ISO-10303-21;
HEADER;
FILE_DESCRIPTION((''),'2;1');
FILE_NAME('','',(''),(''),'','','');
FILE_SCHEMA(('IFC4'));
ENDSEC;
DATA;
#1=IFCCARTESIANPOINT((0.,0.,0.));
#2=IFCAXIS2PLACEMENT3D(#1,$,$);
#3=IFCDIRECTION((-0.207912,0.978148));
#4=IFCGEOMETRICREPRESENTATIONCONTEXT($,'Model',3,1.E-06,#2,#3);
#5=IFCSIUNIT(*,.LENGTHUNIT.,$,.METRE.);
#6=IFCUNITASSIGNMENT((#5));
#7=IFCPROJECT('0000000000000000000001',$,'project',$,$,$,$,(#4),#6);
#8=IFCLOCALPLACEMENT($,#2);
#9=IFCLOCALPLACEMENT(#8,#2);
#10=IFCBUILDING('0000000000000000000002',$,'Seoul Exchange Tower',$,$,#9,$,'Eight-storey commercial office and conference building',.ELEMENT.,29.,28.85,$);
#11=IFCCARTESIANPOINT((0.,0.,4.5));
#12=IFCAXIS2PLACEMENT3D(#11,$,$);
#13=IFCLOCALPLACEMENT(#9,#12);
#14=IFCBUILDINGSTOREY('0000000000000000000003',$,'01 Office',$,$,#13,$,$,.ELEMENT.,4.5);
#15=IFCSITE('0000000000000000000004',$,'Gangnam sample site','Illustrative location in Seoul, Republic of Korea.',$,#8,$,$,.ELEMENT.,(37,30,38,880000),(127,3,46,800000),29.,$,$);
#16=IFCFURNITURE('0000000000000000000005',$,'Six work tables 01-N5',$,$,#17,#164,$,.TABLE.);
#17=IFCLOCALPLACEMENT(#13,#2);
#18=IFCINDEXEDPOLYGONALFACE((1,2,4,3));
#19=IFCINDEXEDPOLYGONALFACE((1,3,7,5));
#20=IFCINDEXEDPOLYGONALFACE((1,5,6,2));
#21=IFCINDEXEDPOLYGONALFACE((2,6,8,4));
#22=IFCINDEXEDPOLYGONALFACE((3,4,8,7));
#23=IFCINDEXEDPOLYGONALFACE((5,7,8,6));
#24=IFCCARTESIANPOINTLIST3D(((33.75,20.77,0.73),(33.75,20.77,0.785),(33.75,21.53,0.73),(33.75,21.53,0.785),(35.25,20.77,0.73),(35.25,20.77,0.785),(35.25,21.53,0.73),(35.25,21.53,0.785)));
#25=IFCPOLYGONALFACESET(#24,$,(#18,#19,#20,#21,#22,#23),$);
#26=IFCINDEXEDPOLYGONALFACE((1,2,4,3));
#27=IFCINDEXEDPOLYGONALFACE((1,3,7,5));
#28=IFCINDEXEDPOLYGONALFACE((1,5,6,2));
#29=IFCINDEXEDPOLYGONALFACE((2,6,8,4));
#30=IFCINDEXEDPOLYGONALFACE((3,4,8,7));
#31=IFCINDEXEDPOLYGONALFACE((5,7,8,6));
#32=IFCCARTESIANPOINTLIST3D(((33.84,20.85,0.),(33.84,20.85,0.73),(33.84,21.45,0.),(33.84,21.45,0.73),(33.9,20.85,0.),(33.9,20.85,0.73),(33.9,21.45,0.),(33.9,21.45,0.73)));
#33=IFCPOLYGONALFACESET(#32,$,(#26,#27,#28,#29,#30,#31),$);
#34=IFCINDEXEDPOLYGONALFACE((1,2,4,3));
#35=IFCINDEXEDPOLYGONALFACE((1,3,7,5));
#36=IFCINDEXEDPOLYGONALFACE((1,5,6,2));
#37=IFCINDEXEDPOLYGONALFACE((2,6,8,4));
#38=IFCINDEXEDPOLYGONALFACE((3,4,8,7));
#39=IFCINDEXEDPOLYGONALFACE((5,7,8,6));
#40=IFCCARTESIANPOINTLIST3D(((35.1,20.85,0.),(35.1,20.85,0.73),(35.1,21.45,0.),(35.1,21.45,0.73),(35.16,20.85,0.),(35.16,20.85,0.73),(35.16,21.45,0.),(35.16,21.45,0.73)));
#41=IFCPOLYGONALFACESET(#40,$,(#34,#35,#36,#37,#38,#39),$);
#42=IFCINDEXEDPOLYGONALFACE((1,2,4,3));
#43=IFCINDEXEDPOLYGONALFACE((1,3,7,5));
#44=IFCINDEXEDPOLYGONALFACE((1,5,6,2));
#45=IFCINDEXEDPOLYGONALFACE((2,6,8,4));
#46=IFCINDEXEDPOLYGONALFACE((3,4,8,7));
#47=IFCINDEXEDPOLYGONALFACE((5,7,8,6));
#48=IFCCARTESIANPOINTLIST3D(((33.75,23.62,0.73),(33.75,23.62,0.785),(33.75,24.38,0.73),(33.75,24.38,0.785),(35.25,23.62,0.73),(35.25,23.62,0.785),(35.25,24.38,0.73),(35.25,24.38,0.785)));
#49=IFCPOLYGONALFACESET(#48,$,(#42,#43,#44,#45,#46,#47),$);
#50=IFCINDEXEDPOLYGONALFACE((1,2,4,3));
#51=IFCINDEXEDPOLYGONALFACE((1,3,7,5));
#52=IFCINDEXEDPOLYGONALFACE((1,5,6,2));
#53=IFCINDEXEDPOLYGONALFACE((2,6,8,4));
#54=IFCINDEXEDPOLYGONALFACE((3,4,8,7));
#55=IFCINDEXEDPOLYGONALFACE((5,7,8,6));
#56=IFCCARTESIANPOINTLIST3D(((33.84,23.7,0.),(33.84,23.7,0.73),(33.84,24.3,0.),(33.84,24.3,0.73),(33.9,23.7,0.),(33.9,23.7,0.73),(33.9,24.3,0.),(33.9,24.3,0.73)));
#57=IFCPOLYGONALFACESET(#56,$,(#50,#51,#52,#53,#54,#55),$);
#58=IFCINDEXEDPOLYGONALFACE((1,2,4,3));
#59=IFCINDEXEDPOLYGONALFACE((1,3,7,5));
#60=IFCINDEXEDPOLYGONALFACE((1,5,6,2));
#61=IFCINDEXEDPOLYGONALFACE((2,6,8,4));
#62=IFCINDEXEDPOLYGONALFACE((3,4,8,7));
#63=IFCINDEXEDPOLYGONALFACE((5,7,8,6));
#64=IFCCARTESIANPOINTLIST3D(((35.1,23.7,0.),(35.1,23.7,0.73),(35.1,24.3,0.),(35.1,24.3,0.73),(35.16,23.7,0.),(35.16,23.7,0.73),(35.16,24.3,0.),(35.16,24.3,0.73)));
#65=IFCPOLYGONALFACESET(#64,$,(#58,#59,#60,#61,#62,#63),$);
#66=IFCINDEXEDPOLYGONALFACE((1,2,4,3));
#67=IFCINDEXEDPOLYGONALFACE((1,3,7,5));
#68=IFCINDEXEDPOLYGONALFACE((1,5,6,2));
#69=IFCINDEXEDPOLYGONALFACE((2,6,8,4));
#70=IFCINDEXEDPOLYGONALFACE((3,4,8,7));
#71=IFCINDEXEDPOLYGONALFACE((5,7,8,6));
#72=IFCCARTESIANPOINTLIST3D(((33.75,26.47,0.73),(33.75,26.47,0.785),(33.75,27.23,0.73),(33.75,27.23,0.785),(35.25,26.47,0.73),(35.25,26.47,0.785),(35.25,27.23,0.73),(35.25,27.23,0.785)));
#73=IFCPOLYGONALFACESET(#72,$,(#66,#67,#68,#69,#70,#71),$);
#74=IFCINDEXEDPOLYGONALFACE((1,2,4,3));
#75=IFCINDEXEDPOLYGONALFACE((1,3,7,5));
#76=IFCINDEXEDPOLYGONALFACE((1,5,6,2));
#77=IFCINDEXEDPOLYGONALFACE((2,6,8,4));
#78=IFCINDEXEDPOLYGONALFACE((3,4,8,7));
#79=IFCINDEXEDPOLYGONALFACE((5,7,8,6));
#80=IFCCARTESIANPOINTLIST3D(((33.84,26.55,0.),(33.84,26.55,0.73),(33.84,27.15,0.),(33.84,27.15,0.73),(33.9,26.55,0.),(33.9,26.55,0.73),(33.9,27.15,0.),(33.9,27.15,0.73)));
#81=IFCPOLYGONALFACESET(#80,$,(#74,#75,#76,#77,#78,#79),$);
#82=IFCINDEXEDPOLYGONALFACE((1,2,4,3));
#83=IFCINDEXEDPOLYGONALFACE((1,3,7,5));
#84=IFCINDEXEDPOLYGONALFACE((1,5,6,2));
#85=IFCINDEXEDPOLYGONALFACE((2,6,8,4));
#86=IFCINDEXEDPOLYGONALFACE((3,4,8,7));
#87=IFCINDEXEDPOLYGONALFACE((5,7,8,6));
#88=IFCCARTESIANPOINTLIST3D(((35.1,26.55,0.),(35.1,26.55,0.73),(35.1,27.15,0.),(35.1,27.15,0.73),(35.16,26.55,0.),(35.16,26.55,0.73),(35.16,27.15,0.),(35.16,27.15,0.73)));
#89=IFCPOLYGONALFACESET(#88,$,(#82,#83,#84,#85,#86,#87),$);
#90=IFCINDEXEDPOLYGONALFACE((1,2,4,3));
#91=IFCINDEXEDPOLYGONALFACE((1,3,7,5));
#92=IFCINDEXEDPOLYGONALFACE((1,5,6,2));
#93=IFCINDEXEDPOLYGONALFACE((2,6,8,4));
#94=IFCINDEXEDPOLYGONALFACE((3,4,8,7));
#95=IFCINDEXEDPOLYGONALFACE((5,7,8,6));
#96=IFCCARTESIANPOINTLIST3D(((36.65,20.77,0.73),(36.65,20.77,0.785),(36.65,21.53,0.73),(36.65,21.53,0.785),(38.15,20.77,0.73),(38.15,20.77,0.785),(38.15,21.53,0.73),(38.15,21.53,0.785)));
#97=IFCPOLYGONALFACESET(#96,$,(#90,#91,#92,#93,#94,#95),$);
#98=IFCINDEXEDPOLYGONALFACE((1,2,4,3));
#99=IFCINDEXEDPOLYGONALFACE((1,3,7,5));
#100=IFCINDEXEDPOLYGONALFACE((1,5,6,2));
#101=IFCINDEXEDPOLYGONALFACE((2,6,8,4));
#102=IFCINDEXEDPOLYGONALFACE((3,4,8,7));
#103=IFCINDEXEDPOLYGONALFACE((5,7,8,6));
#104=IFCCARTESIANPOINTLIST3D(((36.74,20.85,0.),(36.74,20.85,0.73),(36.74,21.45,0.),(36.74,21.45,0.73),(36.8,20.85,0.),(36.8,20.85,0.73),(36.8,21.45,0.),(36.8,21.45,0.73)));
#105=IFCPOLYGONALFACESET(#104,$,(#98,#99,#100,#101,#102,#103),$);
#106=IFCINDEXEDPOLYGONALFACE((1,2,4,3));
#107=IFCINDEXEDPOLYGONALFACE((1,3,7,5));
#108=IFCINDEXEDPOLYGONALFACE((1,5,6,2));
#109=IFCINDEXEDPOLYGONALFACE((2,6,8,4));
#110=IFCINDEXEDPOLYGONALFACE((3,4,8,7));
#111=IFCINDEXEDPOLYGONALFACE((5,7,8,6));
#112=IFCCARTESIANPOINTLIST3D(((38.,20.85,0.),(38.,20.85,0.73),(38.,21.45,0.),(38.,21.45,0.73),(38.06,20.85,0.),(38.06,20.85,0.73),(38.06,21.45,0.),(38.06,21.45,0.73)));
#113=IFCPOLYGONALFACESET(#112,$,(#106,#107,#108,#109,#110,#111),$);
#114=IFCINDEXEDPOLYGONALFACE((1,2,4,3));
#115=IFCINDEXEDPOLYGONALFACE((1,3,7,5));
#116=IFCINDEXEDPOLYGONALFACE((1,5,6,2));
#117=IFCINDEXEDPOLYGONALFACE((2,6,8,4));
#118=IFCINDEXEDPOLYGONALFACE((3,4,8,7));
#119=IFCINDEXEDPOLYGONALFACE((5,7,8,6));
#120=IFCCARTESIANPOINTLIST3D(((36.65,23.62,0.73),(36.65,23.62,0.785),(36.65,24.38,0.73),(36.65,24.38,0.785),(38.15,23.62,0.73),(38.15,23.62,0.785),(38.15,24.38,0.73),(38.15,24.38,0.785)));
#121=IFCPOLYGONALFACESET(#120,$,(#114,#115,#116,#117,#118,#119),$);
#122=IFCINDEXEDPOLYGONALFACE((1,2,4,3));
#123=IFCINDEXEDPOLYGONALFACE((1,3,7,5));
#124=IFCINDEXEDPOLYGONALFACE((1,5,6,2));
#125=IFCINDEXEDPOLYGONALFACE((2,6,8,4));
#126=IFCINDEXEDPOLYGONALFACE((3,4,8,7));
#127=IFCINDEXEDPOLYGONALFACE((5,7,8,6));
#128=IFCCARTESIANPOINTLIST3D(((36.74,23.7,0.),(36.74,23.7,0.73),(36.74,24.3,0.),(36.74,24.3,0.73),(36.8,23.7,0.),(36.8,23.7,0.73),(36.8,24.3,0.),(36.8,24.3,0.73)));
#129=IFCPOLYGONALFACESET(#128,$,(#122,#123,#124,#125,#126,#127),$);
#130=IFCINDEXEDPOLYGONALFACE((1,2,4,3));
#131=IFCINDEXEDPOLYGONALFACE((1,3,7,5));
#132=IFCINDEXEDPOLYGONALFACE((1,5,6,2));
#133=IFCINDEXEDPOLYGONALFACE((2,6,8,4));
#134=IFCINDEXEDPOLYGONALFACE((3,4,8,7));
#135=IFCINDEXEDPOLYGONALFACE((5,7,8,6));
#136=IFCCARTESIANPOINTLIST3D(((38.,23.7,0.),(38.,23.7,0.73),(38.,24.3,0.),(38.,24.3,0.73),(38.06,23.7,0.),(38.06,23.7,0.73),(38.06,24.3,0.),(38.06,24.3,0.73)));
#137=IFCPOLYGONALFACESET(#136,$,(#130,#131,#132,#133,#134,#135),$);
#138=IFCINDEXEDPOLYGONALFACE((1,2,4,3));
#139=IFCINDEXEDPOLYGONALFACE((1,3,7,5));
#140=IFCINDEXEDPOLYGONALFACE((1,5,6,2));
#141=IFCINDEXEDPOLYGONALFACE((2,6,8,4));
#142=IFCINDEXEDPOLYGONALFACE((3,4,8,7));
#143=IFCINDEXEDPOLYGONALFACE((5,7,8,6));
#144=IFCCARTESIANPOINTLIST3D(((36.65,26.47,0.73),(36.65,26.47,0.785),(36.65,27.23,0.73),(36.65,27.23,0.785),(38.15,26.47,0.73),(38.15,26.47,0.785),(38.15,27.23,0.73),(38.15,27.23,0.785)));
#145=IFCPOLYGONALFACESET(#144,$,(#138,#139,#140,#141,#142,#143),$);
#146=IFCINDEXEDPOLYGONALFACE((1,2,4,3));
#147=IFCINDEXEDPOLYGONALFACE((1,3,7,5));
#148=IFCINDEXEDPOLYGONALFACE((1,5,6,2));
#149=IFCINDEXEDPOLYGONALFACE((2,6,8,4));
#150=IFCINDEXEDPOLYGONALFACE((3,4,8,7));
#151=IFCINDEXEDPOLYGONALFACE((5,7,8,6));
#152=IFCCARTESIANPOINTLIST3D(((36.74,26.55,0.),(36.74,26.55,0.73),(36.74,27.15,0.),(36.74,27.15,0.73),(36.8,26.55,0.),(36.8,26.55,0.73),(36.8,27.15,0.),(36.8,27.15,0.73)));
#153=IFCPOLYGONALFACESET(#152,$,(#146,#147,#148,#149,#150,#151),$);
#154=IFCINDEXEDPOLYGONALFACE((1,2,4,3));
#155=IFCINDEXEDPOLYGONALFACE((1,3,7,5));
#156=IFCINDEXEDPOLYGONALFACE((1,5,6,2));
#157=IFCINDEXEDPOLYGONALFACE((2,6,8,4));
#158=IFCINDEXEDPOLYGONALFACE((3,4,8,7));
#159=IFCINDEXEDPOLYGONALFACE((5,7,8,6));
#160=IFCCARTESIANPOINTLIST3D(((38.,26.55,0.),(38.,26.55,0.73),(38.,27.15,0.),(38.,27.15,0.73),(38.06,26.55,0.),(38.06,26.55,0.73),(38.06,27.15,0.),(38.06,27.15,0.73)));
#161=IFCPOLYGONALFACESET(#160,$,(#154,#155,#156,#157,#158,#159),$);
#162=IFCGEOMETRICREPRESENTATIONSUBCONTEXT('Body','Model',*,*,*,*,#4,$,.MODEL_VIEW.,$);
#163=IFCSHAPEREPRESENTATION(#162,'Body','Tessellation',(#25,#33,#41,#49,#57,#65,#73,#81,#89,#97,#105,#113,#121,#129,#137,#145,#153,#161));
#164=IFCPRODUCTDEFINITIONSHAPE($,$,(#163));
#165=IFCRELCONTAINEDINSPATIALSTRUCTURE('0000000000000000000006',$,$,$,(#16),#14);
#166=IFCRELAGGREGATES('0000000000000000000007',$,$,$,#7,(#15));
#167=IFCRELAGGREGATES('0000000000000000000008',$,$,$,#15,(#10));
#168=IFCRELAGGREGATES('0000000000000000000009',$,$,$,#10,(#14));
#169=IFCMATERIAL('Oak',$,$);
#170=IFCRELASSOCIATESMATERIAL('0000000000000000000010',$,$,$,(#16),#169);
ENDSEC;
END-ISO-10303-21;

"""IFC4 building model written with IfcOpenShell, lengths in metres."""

from ifc_helpers import new_model, si_unit, direction, frame, frame_2d, origin, place, context, subcontext, project, spatial, rectangle, extrude, material, element, save


model = new_model("IFC4")

# Units and contexts
model_context = context("Model", 3, precision=1e-06, world=origin(), true_north=direction((-0.207912, 0.978148)))
body_context = subcontext(model_context, "Body", "Model", "MODEL_VIEW")
ifc_project = project(units=[si_unit("LENGTHUNIT", "METRE")], contexts=[model_context])

# Site, building, storey
site_placement = place(None, origin())
site = spatial("IfcSite", under=ifc_project, at=site_placement, Name="Gangnam sample site", Description="Illustrative location in Seoul, Republic of Korea.", CompositionType="ELEMENT", RefLatitude=(37, 30, 38, 880000), RefLongitude=(127, 3, 46, 800000), RefElevation=29.0)
building_placement = place(site_placement, origin())
building = spatial("IfcBuilding", under=site, at=building_placement, Name="Seoul Exchange Tower", LongName="Eight-storey commercial office and conference building", CompositionType="ELEMENT", ElevationOfRefHeight=29.0, ElevationOfTerrain=28.85)
storey_placement = place(building_placement, frame((0.0, 0.0, 4.5)))
storey = spatial("IfcBuildingStorey", under=building, at=storey_placement, Name="01 Office", CompositionType="ELEMENT", Elevation=4.5)

# Shared definitions
placement_1 = place(storey_placement, origin())

# Furniture
ifc_material_1 = material(Name="Oak")
element("IfcFurniture", 1, at=placement_1, inside=storey, material=ifc_material_1, Name="Six work tables 01-N5", PredefinedType="TABLE", context=body_context, shape_type="SweptSolid", body=[
    extrude(rectangle(XDim=1.5, YDim=0.76, at=frame_2d((0.75, 0.38))), frame((33.75, 20.77, 0.73)), (0.0, 0.0, 1.0), 0.055),
    extrude(rectangle(XDim=0.06, YDim=0.6, at=frame_2d((0.03, 0.3))), frame((33.84, 20.85, 0.0)), (0.0, 0.0, 1.0), 0.73),
    extrude(rectangle(XDim=0.06, YDim=0.6, at=frame_2d((0.03, 0.3))), frame((35.1, 20.85, 0.0)), (0.0, 0.0, 1.0), 0.73),
    extrude(rectangle(XDim=1.5, YDim=0.76, at=frame_2d((0.75, 0.38))), frame((33.75, 23.62, 0.73)), (0.0, 0.0, 1.0), 0.055),
    extrude(rectangle(XDim=0.06, YDim=0.6, at=frame_2d((0.03, 0.3))), frame((33.84, 23.7, 0.0)), (0.0, 0.0, 1.0), 0.73),
    extrude(rectangle(XDim=0.06, YDim=0.6, at=frame_2d((0.03, 0.3))), frame((35.1, 23.7, 0.0)), (0.0, 0.0, 1.0), 0.73),
    extrude(rectangle(XDim=1.5, YDim=0.76, at=frame_2d((0.75, 0.38))), frame((33.75, 26.47, 0.73)), (0.0, 0.0, 1.0), 0.055),
    extrude(rectangle(XDim=0.06, YDim=0.6, at=frame_2d((0.03, 0.3))), frame((33.84, 26.55, 0.0)), (0.0, 0.0, 1.0), 0.73),
    extrude(rectangle(XDim=0.06, YDim=0.6, at=frame_2d((0.03, 0.3))), frame((35.1, 26.55, 0.0)), (0.0, 0.0, 1.0), 0.73),
    extrude(rectangle(XDim=1.5, YDim=0.76, at=frame_2d((0.75, 0.38))), frame((36.65, 20.77, 0.73)), (0.0, 0.0, 1.0), 0.055),
    extrude(rectangle(XDim=0.06, YDim=0.6, at=frame_2d((0.03, 0.3))), frame((36.74, 20.85, 0.0)), (0.0, 0.0, 1.0), 0.73),
    extrude(rectangle(XDim=0.06, YDim=0.6, at=frame_2d((0.03, 0.3))), frame((38.0, 20.85, 0.0)), (0.0, 0.0, 1.0), 0.73),
    extrude(rectangle(XDim=1.5, YDim=0.76, at=frame_2d((0.75, 0.38))), frame((36.65, 23.62, 0.73)), (0.0, 0.0, 1.0), 0.055),
    extrude(rectangle(XDim=0.06, YDim=0.6, at=frame_2d((0.03, 0.3))), frame((36.74, 23.7, 0.0)), (0.0, 0.0, 1.0), 0.73),
    extrude(rectangle(XDim=0.06, YDim=0.6, at=frame_2d((0.03, 0.3))), frame((38.0, 23.7, 0.0)), (0.0, 0.0, 1.0), 0.73),
    extrude(rectangle(XDim=1.5, YDim=0.76, at=frame_2d((0.75, 0.38))), frame((36.65, 26.47, 0.73)), (0.0, 0.0, 1.0), 0.055),
    extrude(rectangle(XDim=0.06, YDim=0.6, at=frame_2d((0.03, 0.3))), frame((36.74, 26.55, 0.0)), (0.0, 0.0, 1.0), 0.73),
    extrude(rectangle(XDim=0.06, YDim=0.6, at=frame_2d((0.03, 0.3))), frame((38.0, 26.55, 0.0)), (0.0, 0.0, 1.0), 0.73),
])

save(model, "model.ifc")
